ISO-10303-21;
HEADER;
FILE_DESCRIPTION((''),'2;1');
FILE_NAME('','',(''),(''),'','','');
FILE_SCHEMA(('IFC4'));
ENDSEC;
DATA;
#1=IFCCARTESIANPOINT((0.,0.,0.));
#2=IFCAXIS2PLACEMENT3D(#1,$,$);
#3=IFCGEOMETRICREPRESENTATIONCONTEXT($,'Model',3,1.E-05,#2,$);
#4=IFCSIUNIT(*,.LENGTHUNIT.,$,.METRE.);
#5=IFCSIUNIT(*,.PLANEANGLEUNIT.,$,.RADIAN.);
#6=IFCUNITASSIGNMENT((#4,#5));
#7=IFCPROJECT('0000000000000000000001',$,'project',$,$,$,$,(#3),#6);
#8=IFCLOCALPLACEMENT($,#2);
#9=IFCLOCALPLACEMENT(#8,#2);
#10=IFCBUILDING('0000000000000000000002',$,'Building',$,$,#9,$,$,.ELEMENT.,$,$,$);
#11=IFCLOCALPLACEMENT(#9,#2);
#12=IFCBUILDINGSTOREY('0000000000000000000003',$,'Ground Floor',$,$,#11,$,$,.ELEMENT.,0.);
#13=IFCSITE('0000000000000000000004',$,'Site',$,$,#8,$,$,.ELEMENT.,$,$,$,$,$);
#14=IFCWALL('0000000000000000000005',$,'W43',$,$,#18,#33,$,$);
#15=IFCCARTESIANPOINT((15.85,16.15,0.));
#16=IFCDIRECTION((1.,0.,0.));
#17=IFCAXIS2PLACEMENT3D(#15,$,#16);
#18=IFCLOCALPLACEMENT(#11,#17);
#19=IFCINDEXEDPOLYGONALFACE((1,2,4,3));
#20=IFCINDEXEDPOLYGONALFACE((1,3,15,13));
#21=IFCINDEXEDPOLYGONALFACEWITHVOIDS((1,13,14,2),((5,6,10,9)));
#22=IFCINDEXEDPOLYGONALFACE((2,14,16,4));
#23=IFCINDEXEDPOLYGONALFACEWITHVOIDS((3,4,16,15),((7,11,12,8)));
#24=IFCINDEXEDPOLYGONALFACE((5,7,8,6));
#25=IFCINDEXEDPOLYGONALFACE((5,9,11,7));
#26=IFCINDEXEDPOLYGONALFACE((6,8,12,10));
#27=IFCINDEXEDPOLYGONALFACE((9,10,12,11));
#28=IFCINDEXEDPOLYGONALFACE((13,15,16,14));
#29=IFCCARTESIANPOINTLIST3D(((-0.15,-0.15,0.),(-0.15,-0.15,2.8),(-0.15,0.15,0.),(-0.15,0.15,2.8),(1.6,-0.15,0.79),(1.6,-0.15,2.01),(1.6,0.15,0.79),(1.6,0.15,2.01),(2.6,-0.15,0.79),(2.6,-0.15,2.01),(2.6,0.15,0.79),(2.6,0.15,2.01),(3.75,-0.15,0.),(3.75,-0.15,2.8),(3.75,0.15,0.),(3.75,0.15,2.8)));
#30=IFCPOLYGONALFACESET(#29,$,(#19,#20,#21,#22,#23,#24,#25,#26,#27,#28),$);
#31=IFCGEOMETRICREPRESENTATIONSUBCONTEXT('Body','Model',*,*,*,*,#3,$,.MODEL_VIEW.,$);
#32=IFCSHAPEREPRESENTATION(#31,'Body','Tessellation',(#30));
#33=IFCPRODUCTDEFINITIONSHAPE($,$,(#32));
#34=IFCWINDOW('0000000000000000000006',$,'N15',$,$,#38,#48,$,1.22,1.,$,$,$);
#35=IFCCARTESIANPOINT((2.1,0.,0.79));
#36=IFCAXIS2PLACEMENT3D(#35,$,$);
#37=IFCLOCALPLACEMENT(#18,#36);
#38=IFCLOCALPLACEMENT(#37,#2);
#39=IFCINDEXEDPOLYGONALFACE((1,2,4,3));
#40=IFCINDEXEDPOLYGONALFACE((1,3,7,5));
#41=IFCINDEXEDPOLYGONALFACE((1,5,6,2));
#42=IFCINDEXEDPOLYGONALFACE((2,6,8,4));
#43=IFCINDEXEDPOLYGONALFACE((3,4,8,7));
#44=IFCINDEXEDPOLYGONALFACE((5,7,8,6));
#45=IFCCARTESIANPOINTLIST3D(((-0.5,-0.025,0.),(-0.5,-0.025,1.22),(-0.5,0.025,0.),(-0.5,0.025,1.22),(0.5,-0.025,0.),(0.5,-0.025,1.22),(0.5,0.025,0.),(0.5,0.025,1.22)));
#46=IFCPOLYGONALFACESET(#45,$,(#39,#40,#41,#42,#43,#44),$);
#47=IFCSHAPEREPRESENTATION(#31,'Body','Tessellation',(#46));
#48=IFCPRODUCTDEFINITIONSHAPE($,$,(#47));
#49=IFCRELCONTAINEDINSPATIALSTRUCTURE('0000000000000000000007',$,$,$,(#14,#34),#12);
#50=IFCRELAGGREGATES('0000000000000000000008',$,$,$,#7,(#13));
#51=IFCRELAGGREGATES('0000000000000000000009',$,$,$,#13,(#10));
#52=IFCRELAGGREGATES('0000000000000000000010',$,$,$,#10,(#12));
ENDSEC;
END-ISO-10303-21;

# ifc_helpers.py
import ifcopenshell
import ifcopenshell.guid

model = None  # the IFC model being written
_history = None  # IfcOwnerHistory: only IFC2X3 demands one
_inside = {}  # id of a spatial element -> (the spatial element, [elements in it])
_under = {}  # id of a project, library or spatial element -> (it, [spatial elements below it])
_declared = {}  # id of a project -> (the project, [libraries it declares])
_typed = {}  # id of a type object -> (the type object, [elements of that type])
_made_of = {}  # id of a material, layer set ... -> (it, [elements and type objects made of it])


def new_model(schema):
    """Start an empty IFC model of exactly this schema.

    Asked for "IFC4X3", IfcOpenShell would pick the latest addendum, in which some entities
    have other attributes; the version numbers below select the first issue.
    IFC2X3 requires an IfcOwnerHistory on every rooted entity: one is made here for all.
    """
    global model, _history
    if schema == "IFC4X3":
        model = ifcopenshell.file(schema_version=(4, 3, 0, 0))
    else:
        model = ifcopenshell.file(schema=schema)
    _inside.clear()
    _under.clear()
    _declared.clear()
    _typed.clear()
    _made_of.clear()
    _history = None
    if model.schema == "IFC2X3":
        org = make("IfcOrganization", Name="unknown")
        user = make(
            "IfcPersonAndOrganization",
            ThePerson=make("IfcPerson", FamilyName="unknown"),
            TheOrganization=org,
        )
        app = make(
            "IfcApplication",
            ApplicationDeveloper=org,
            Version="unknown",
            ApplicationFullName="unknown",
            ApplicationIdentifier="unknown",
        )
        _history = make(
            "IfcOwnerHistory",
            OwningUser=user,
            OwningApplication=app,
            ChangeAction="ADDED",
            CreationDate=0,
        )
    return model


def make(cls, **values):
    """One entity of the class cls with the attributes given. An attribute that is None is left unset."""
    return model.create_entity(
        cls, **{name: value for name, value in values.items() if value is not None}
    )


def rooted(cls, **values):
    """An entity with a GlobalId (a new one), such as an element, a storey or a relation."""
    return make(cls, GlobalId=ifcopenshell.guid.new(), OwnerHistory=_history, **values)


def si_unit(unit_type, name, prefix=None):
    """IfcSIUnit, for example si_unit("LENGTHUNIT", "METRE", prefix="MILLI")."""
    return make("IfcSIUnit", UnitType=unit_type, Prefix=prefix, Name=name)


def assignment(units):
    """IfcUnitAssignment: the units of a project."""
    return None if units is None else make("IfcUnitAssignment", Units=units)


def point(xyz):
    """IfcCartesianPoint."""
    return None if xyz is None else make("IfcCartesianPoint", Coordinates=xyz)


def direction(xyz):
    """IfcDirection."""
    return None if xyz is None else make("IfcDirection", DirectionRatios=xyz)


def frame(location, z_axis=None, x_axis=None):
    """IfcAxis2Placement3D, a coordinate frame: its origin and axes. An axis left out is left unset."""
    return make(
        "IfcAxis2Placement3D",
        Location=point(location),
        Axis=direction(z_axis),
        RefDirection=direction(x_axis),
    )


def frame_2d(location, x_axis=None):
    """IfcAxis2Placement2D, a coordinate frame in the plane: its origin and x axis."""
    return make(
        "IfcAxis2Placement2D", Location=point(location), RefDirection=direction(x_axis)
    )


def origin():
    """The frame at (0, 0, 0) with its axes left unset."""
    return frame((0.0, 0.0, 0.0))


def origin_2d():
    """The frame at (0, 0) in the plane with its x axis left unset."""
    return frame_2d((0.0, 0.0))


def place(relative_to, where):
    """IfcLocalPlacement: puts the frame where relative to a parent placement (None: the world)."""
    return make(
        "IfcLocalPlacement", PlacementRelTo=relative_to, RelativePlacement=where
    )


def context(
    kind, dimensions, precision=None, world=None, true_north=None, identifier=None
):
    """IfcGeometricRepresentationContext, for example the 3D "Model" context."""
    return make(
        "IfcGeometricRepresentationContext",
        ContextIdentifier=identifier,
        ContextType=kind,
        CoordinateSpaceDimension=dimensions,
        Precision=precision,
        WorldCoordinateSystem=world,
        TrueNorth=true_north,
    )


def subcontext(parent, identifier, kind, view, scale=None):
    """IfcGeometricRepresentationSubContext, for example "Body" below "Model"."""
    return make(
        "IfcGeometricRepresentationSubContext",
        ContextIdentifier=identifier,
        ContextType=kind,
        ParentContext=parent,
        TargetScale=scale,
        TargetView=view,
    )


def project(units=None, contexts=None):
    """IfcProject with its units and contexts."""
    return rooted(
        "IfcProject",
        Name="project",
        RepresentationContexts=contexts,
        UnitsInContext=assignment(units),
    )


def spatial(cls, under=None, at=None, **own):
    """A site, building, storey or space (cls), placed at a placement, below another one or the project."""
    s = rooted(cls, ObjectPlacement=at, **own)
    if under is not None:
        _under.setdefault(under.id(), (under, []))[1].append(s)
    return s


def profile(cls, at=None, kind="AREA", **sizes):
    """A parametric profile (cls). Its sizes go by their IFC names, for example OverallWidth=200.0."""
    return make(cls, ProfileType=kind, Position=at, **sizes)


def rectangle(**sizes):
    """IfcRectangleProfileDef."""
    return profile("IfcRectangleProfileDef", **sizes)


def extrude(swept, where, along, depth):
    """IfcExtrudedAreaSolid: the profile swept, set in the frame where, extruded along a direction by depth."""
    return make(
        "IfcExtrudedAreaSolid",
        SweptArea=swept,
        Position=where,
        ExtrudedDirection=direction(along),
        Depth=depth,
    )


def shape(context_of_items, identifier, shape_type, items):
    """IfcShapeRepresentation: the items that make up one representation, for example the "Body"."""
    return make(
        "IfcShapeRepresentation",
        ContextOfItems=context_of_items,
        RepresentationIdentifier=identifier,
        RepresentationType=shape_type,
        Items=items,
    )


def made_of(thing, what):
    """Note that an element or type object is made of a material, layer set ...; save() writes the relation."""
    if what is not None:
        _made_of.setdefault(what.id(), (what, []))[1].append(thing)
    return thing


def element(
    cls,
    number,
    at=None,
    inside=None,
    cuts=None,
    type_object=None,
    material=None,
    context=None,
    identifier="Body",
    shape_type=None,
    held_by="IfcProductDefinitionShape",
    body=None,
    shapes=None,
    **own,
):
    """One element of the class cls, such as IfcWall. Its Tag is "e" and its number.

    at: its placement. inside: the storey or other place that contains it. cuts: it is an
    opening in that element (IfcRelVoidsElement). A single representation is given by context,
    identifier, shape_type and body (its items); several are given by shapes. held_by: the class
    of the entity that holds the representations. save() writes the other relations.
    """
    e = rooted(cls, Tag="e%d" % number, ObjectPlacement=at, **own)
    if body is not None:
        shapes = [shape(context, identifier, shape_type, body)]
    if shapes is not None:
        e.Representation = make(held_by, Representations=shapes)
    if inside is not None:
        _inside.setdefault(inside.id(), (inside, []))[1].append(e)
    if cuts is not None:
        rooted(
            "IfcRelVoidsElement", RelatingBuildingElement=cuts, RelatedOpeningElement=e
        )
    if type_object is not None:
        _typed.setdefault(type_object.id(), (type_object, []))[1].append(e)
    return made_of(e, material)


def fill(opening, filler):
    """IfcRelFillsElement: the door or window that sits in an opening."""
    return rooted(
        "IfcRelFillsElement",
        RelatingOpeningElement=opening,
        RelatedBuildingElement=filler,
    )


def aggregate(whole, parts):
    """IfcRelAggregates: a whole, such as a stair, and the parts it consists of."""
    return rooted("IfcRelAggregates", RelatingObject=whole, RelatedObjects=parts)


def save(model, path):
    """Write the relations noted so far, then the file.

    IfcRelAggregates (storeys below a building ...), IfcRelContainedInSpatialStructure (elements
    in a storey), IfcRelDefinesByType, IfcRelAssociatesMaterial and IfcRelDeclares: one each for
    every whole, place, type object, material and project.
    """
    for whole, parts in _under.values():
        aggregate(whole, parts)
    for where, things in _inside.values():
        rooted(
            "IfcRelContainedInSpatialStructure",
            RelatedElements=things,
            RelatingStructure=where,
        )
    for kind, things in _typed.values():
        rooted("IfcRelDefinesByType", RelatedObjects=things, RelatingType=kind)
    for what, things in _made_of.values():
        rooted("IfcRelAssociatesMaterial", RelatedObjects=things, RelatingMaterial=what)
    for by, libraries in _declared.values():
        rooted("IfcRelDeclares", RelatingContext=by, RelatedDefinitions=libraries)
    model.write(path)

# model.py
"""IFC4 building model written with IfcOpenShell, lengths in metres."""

from ifc_helpers import new_model, si_unit, frame, frame_2d, origin, origin_2d, place, context, subcontext, project, spatial, rectangle, extrude, element, fill, save


model = new_model("IFC4")

# Units and contexts
model_context = context("Model", 3, precision=1e-05, world=origin())
body_context = subcontext(model_context, "Body", "Model", "MODEL_VIEW")
ifc_project = project(units=[si_unit("LENGTHUNIT", "METRE"), si_unit("PLANEANGLEUNIT", "RADIAN")], contexts=[model_context])

# Site, building, storey
site_placement = place(None, origin())
site = spatial("IfcSite", under=ifc_project, at=site_placement, Name="Site", CompositionType="ELEMENT")
building_placement = place(site_placement, origin())
building = spatial("IfcBuilding", under=site, at=building_placement, Name="Building", CompositionType="ELEMENT")
storey_placement = place(building_placement, origin())
storey = spatial("IfcBuildingStorey", under=building, at=storey_placement, Name="Ground Floor", CompositionType="ELEMENT", Elevation=0.0)

# Wall, opening, window
wall_1_placement = place(storey_placement, frame((15.85, 16.15, 0.0), x_axis=(1.0, 0.0, 0.0)))
wall_1 = element("IfcWall", 1, at=wall_1_placement, inside=storey, Name="W43", context=body_context, shape_type="SweptSolid", body=[
    extrude(rectangle(XDim=3.9, YDim=0.3, at=frame_2d((1.8, 0.0))), origin(), (0.0, 0.0, 1.0), 2.8),
])
opening_1_placement = place(wall_1_placement, frame((2.1, 0.0, 0.79)))
opening_1 = element("IfcOpeningElement", 2, at=opening_1_placement, cuts=wall_1, context=body_context, shape_type="SweptSolid", body=[
    extrude(rectangle(XDim=1.0, YDim=0.4, at=origin_2d()), origin(), (0.0, 0.0, 1.0), 1.22),
])
window_1_placement = place(opening_1_placement, origin())
window_1 = element("IfcWindow", 3, at=window_1_placement, inside=storey, Name="N15", OverallHeight=1.22, OverallWidth=1.0, context=body_context, shape_type="SweptSolid", body=[
    extrude(rectangle(XDim=1.0, YDim=0.05, at=origin_2d()), origin(), (0.0, 0.0, 1.0), 1.22),
])
fill(opening_1, window_1)

save(model, "model.ifc")
